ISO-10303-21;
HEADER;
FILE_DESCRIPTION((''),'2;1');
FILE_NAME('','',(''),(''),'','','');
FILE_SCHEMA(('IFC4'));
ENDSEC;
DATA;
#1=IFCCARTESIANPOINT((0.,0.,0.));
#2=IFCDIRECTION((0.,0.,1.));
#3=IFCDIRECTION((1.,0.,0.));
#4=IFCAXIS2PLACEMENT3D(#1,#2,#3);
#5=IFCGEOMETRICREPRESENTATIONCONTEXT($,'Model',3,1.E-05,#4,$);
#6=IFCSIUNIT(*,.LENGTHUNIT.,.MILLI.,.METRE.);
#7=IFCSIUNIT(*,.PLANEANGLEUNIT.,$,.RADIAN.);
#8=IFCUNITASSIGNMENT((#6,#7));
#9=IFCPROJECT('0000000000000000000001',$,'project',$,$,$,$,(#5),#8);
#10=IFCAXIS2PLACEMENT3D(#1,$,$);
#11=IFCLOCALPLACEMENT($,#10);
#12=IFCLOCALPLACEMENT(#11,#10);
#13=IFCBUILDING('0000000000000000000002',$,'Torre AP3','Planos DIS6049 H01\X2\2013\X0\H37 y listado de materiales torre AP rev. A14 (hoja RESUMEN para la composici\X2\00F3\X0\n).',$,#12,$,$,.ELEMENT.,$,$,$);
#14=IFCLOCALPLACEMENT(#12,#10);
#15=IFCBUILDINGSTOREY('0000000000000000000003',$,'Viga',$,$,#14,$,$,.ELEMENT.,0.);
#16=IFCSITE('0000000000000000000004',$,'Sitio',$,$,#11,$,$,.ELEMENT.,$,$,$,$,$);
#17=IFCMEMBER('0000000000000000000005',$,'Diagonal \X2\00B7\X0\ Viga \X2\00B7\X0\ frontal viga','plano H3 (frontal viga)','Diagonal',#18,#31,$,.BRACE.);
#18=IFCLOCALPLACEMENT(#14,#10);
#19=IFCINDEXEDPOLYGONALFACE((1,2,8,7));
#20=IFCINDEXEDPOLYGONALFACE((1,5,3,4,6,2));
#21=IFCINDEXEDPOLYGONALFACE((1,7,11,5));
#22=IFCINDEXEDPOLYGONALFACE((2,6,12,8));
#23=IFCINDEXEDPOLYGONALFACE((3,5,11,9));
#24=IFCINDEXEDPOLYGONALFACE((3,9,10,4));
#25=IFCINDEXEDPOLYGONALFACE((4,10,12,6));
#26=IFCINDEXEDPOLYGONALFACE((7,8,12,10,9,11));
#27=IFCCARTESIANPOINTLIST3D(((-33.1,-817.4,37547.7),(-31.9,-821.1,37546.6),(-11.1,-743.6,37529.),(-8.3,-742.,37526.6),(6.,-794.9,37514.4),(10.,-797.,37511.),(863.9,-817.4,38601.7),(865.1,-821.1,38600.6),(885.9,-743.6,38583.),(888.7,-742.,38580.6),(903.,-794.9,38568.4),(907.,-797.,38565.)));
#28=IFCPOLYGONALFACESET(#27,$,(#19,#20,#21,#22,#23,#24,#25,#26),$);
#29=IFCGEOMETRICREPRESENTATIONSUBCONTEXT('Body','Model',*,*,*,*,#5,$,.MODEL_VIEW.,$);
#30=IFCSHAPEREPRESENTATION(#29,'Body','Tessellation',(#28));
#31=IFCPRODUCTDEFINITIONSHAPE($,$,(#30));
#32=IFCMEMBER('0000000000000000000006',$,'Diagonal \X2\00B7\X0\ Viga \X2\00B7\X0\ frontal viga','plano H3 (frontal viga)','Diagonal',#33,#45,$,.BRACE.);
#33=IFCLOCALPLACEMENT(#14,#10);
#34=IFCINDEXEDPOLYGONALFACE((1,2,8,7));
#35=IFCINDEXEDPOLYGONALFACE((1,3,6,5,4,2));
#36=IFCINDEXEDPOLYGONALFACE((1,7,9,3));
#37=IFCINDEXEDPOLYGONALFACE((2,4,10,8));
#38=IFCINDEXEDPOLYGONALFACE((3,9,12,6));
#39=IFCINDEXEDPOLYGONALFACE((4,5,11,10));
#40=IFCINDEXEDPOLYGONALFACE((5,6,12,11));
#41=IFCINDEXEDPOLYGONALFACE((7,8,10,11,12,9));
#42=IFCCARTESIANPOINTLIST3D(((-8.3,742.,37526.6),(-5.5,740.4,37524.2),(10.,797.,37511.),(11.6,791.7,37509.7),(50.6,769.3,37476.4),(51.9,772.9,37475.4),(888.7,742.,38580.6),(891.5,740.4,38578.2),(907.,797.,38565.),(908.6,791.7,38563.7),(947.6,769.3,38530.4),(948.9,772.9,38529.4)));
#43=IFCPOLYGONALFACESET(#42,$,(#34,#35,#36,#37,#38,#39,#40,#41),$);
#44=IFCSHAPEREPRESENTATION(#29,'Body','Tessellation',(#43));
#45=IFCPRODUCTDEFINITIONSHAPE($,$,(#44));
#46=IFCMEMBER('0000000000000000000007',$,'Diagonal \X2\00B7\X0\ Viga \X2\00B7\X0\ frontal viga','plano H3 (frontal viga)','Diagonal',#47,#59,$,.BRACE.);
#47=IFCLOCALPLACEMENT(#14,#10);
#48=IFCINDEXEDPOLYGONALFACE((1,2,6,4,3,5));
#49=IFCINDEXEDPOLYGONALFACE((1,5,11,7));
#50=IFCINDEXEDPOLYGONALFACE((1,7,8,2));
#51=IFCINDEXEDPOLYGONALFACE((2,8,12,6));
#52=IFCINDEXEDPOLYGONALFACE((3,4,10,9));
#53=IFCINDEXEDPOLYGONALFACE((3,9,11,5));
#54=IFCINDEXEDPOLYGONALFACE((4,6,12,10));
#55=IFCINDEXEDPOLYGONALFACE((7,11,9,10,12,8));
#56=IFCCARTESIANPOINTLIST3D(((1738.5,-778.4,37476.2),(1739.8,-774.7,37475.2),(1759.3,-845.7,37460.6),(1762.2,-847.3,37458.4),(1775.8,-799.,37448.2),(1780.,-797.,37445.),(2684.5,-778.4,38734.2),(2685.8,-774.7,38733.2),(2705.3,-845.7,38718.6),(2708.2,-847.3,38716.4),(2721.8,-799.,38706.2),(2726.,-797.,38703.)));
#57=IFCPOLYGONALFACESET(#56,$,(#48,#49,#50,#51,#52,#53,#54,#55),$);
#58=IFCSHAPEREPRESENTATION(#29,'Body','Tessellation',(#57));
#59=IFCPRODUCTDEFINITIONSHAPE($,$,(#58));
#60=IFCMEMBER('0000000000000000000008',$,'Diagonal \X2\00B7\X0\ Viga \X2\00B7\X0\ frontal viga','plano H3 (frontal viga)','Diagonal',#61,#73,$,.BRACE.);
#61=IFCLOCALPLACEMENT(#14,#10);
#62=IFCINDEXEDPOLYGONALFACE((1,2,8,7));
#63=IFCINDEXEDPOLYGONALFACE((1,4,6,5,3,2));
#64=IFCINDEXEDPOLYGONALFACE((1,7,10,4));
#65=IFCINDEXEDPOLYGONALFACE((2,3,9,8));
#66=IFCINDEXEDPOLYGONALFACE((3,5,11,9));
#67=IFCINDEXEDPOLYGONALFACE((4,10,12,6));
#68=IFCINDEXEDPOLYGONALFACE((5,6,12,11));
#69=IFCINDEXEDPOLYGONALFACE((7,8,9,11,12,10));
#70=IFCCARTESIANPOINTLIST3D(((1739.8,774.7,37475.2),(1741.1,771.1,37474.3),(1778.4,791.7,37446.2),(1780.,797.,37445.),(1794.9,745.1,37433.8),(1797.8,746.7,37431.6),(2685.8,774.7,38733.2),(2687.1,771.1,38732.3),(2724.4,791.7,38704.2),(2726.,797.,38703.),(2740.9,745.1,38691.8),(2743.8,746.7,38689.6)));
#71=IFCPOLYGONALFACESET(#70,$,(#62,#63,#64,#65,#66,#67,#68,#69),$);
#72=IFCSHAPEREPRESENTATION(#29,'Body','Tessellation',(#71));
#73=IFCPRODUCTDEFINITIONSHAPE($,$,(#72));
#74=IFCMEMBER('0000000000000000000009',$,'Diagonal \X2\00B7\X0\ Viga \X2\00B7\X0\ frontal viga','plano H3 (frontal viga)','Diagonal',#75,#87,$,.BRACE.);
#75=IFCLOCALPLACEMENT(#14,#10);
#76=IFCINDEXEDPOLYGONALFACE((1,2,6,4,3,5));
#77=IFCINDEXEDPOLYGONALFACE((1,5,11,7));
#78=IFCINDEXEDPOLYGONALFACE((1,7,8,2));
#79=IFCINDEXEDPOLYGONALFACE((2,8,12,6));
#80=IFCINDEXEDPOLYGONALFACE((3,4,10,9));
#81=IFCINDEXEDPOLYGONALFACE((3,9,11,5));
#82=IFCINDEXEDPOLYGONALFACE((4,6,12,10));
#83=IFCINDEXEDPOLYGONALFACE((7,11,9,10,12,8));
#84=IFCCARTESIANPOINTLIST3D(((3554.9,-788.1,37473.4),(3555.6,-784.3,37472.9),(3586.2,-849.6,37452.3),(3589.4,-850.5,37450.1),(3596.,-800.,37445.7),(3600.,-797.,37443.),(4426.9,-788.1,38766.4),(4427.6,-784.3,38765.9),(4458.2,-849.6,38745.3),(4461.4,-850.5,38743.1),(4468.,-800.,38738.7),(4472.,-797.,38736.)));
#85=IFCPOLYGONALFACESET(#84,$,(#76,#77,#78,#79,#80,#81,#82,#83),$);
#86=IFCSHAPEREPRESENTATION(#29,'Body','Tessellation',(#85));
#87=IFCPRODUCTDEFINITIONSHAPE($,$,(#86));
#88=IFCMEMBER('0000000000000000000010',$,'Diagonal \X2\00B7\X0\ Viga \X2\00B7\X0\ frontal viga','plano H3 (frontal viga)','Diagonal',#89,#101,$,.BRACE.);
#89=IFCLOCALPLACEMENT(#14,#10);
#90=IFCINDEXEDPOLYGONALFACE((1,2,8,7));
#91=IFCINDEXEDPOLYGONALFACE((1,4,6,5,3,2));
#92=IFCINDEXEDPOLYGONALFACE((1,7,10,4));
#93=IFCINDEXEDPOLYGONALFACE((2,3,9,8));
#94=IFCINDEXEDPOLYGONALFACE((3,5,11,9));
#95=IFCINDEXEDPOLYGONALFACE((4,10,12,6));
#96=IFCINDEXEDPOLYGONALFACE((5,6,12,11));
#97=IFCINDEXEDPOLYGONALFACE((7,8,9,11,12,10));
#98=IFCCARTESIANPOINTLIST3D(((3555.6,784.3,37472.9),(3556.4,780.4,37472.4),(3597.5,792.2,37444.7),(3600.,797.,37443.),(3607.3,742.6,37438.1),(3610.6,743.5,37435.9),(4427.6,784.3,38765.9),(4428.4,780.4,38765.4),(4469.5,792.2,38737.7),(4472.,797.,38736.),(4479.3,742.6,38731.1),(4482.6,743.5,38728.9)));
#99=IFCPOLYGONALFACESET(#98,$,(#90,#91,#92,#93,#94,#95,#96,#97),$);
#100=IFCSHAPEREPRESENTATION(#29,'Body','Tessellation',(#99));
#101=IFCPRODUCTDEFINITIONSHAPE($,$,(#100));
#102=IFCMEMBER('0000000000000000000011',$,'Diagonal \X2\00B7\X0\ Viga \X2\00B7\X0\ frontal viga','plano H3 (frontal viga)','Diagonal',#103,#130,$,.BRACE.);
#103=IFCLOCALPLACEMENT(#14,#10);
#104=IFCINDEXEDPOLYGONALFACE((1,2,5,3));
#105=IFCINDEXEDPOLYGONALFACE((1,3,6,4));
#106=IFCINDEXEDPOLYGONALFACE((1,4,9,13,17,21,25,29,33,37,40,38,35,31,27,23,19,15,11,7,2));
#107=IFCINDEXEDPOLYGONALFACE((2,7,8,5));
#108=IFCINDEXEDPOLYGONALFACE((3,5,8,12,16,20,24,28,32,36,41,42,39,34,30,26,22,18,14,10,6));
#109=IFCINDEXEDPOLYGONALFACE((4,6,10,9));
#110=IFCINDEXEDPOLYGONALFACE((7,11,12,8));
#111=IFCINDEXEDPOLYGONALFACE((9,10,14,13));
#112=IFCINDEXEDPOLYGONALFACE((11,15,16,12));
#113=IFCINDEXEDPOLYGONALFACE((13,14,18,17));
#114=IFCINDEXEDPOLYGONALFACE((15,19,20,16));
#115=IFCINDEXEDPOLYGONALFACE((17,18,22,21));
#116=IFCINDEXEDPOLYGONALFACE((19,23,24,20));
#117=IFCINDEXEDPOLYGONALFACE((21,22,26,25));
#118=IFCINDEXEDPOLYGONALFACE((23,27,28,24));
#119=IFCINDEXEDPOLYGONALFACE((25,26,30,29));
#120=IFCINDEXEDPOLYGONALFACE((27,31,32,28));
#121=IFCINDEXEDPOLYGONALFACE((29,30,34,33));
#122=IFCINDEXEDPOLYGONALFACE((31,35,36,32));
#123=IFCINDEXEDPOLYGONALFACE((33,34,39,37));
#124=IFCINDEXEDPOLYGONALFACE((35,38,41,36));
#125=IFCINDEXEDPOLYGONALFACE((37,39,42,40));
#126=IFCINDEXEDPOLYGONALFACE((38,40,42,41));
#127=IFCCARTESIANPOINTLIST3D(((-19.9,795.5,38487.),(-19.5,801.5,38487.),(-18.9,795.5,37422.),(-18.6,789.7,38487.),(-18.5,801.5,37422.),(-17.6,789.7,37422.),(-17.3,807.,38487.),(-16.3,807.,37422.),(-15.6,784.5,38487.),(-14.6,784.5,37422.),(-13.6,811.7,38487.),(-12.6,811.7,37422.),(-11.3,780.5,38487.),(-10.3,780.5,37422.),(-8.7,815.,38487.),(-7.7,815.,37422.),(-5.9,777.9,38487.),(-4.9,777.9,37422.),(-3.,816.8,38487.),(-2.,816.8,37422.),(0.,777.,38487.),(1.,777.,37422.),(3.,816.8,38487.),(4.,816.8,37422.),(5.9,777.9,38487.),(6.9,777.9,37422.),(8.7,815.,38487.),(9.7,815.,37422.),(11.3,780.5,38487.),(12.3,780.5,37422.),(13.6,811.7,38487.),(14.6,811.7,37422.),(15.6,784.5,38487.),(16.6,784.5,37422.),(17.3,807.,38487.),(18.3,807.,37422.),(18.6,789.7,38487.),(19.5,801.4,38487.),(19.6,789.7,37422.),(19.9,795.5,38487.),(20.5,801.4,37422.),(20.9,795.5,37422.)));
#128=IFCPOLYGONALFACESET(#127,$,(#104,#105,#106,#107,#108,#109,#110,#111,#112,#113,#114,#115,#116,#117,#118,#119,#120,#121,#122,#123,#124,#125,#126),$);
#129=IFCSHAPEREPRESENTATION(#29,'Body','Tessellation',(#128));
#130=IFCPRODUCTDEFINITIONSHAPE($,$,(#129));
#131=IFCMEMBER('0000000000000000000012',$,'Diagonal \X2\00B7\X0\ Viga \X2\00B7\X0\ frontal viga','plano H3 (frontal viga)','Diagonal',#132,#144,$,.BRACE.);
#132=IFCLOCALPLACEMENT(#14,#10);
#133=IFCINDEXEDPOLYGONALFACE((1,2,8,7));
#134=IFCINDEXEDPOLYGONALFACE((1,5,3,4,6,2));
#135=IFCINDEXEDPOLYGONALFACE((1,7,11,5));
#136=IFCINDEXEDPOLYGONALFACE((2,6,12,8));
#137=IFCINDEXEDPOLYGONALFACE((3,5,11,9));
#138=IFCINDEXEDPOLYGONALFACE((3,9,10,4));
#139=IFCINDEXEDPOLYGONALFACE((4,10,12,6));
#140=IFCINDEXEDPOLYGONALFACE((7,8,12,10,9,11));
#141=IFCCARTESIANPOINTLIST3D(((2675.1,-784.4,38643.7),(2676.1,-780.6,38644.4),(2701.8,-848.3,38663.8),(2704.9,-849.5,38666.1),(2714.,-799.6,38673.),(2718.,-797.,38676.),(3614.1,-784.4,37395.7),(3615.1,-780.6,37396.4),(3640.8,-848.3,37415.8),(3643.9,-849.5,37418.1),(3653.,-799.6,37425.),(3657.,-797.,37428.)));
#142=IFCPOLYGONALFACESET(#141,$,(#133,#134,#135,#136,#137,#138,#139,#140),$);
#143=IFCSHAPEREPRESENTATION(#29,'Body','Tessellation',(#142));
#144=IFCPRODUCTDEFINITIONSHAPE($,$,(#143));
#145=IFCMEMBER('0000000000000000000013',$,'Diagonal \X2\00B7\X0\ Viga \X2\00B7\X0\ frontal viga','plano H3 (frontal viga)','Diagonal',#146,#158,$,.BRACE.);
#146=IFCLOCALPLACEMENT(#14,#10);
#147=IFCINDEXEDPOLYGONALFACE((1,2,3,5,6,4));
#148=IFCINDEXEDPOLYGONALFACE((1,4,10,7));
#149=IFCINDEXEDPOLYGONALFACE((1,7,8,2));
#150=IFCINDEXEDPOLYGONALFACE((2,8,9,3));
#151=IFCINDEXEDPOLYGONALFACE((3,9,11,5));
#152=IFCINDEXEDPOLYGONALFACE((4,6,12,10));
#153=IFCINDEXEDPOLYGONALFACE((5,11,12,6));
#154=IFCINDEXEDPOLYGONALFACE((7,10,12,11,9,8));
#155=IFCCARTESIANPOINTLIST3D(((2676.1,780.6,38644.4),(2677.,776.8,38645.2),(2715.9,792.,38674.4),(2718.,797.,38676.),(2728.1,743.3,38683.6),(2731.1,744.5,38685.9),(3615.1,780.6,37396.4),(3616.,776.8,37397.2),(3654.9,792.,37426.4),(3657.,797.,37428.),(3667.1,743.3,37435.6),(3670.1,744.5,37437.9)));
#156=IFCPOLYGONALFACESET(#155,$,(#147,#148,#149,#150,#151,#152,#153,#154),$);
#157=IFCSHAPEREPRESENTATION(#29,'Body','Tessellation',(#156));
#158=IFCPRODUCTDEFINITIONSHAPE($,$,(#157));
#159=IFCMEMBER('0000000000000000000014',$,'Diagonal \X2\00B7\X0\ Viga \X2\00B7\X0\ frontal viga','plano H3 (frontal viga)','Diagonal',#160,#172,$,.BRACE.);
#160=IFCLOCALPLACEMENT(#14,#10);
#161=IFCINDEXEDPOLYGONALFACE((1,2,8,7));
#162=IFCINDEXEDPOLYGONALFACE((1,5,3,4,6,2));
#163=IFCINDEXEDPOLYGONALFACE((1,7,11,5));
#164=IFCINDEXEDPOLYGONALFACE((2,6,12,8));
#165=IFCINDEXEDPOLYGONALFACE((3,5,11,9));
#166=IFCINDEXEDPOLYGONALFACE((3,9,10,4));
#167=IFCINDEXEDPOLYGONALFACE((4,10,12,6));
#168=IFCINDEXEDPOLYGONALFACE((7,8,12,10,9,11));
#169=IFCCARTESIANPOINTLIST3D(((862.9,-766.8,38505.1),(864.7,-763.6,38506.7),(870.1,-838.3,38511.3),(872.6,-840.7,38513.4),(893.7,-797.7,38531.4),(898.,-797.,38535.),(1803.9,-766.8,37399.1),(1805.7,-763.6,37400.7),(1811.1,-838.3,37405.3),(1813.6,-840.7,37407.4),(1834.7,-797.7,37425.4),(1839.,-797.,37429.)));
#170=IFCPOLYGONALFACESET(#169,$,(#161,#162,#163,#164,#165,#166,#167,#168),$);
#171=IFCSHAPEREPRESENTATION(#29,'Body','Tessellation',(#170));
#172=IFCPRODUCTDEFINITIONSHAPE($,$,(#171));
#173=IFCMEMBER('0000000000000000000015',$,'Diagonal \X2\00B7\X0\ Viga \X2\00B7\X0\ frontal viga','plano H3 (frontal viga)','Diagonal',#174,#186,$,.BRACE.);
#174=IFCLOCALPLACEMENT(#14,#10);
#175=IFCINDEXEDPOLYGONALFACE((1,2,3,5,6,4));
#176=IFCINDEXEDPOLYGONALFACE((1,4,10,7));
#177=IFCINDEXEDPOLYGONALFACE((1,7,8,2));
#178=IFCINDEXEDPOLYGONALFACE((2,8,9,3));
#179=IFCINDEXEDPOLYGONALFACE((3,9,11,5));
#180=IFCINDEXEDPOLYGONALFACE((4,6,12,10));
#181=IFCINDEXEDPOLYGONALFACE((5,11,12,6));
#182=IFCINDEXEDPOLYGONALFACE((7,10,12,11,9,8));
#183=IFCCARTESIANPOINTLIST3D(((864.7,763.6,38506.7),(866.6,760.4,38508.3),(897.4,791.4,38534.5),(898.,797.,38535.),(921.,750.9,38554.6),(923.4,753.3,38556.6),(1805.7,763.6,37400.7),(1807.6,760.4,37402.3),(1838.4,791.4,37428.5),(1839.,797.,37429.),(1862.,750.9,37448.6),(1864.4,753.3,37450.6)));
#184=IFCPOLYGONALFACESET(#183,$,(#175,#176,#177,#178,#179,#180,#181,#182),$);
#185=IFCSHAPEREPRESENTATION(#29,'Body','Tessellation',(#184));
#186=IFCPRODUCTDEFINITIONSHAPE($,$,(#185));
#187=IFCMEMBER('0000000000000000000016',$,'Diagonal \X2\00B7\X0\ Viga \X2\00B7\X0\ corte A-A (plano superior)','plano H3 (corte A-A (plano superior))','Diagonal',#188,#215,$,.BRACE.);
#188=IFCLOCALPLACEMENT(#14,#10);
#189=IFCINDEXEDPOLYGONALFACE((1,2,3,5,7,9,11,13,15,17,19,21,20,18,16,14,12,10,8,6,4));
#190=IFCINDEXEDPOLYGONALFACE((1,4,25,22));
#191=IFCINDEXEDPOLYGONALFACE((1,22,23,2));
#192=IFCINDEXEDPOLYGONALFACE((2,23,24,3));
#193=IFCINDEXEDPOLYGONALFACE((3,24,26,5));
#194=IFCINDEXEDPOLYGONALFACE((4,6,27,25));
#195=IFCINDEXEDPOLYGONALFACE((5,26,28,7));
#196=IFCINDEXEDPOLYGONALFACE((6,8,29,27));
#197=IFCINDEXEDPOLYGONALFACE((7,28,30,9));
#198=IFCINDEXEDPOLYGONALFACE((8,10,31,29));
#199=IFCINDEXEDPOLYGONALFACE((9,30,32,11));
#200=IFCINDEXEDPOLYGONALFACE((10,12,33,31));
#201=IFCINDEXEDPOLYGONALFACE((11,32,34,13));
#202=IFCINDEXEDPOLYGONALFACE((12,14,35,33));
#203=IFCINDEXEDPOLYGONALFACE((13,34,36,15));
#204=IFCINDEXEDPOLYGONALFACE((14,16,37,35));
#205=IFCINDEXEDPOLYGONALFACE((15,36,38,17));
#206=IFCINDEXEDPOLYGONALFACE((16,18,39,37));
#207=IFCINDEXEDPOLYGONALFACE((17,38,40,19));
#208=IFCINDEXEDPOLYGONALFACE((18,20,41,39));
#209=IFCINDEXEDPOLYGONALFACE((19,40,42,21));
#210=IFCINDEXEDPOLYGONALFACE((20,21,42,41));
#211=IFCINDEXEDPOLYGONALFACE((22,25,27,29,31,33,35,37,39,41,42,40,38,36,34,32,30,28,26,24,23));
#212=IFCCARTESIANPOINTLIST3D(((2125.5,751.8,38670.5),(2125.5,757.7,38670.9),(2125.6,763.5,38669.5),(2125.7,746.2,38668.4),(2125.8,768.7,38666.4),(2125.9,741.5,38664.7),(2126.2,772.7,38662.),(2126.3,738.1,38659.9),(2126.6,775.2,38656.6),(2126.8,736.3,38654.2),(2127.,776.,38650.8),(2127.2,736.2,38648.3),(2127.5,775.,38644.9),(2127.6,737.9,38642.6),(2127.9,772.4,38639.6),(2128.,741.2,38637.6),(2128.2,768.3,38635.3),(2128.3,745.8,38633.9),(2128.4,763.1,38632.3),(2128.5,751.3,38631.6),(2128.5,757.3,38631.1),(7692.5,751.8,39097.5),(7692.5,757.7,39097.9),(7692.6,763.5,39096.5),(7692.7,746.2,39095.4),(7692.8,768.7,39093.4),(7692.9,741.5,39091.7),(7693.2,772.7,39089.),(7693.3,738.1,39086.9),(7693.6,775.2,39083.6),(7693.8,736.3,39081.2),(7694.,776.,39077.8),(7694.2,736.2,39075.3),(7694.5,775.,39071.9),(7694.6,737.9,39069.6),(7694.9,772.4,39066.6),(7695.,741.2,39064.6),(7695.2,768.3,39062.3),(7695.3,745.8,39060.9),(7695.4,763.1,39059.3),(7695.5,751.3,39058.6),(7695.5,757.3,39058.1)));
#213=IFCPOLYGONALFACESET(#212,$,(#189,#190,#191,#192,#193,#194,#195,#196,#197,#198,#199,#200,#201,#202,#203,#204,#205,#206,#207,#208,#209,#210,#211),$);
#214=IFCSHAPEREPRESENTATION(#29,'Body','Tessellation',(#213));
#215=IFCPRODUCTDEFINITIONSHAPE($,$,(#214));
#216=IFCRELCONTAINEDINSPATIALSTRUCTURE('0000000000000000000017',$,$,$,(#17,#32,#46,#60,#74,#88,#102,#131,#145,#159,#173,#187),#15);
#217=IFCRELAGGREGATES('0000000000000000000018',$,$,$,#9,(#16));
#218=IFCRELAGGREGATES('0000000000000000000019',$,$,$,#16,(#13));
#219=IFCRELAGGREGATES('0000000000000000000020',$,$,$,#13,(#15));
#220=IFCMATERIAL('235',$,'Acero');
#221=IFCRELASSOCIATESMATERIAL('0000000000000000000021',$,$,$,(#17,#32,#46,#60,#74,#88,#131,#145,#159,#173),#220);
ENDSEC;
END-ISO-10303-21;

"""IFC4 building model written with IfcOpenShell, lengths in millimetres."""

from ifc_helpers import new_model, si_unit, frame, frame_2d, origin, origin_with_axes, place, context, subcontext, project, spatial, circle, l_section, extrude, material, element, save


model = new_model("IFC4")

# Units and contexts
model_context = context("Model", 3, precision=1e-05, world=origin_with_axes())
body_context = subcontext(model_context, "Body", "Model", "MODEL_VIEW")
ifc_project = project(units=[si_unit("LENGTHUNIT", "METRE", prefix="MILLI"), si_unit("PLANEANGLEUNIT", "RADIAN")], contexts=[model_context])

# Site, building, storey
site_placement = place(None, origin())
site = spatial("IfcSite", under=ifc_project, at=site_placement, Name="Sitio", CompositionType="ELEMENT")
building_placement = place(site_placement, origin())
building = spatial("IfcBuilding", under=site, at=building_placement, Name="Torre AP3", Description="Planos DIS6049 H01–H37 y listado de materiales torre AP rev. A14 (hoja RESUMEN para la composición).", CompositionType="ELEMENT")
storey_placement = place(building_placement, origin())
storey = spatial("IfcBuildingStorey", under=building, at=storey_placement, Name="Viga", CompositionType="ELEMENT", Elevation=0.0)

# Members
ifc_material = material(Name="235", Category="Acero")
for number, where, z_axis, x_axis, name in (
    (1, (10.0, -797.0, 37511.0), (0.64811, 0.0, 0.761547), (-0.305596, 0.915954, 0.260076), "Diagonal · Viga · frontal viga"),
    (2, (10.0, 797.0, 37511.0), (0.64811, 0.0, 0.761547), (-0.305596, -0.915954, 0.260076), "Diagonal · Viga · frontal viga"),
):
    element("IfcMember", number, at=place(storey_placement, frame(where, z_axis=z_axis, x_axis=x_axis)), inside=storey, material=ifc_material, Name=name, Description="plano H3 (frontal viga)", ObjectType="Diagonal", PredefinedType="BRACE", context=body_context, shape_type="SweptSolid", body=[
        extrude(l_section(Depth=60.0, Width=60.0, Thickness=4.0, at=frame_2d((30.0, 30.0))), None, (0.0, 0.0, 1.0), 1384.0),
    ])
for number, where, z_axis, x_axis, name in (
    (3, (1780.0, -797.0, 37445.0), (0.601016, 0.0, 0.799237), (-0.730849, 0.404737, 0.549589), "Diagonal · Viga · frontal viga"),
    (4, (1780.0, 797.0, 37445.0), (0.601016, 0.0, 0.799237), (-0.730849, -0.404737, 0.549589), "Diagonal · Viga · frontal viga"),
):
    element("IfcMember", number, at=place(storey_placement, frame(where, z_axis=z_axis, x_axis=x_axis)), inside=storey, material=ifc_material, Name=name, Description="plano H3 (frontal viga)", ObjectType="Diagonal", PredefinedType="BRACE", context=body_context, shape_type="SweptSolid", body=[
        extrude(l_section(Depth=55.0, Width=55.0, Thickness=4.0, at=frame_2d((27.5, 27.5))), None, (0.0, 0.0, 1.0), 1574.0),
    ])
for number, where, z_axis, x_axis, name in (
    (5, (3600.0, -797.0, 37443.0), (0.559131, 0.0, 0.829079), (-0.806517, 0.231702, 0.543916), "Diagonal · Viga · frontal viga"),
    (6, (3600.0, 797.0, 37443.0), (0.559131, 0.0, 0.829079), (-0.806517, -0.231702, 0.543916), "Diagonal · Viga · frontal viga"),
):
    element("IfcMember", number, at=place(storey_placement, frame(where, z_axis=z_axis, x_axis=x_axis)), inside=storey, material=ifc_material, Name=name, Description="plano H3 (frontal viga)", ObjectType="Diagonal", PredefinedType="BRACE", context=body_context, shape_type="SweptSolid", body=[
        extrude(l_section(Depth=55.0, Width=55.0, Thickness=4.0, at=frame_2d((27.5, 27.5))), None, (0.0, 0.0, 1.0), 1559.6),
    ])
member_1_placement = place(storey_placement, frame((1.0, 797.0, 37422.0), z_axis=(-0.000939, 0.0, 1.0), x_axis=(-0.000627, -1.0, -0.000001)))
element("IfcMember", 7, at=member_1_placement, inside=storey, Name="Diagonal · Viga · frontal viga", Description="plano H3 (frontal viga)", ObjectType="Diagonal", PredefinedType="BRACE", context=body_context, shape_type="SweptSolid", body=[
    extrude(circle(Radius=20.0), None, (0.0, 0.0, 1.0), 1065.0),
])
for number, where, z_axis, x_axis, name in (
    (8, (3657.0, -797.0, 37428.0), (-0.601229, 0.0, 0.799077), (-0.762614, 0.298631, -0.573794), "Diagonal · Viga · frontal viga"),
    (9, (3657.0, 797.0, 37428.0), (-0.601229, 0.0, 0.799077), (-0.762614, -0.298631, -0.573794), "Diagonal · Viga · frontal viga"),
):
    element("IfcMember", number, at=place(storey_placement, frame(where, z_axis=z_axis, x_axis=x_axis)), inside=storey, material=ifc_material, Name=name, Description="plano H3 (frontal viga)", ObjectType="Diagonal", PredefinedType="BRACE", context=body_context, shape_type="SweptSolid", body=[
        extrude(l_section(Depth=55.0, Width=55.0, Thickness=4.0, at=frame_2d((27.5, 27.5))), None, (0.0, 0.0, 1.0), 1561.8),
    ])
for number, where, z_axis, x_axis, name in (
    (10, (1839.0, -797.0, 37429.0), (-0.648008, 0.0, 0.761633), (-0.605023, 0.607426, -0.514762), "Diagonal · Viga · frontal viga"),
    (11, (1839.0, 797.0, 37429.0), (-0.648008, 0.0, 0.761633), (-0.605023, -0.607426, -0.514762), "Diagonal · Viga · frontal viga"),
):
    element("IfcMember", number, at=place(storey_placement, frame(where, z_axis=z_axis, x_axis=x_axis)), inside=storey, material=ifc_material, Name=name, Description="plano H3 (frontal viga)", ObjectType="Diagonal", PredefinedType="BRACE", context=body_context, shape_type="SweptSolid", body=[
        extrude(l_section(Depth=55.0, Width=55.0, Thickness=4.0, at=frame_2d((27.5, 27.5))), None, (0.0, 0.0, 1.0), 1452.1),
    ])
member_2_placement = place(storey_placement, frame((2127.0, 756.0, 38651.0), z_axis=(0.997071, 0.0, 0.076477), x_axis=(-0.034023, -0.895589, 0.44358)))
element("IfcMember", 12, at=member_2_placement, inside=storey, Name="Diagonal · Viga · corte A-A (plano superior)", Description="plano H3 (corte A-A (plano superior))", ObjectType="Diagonal", PredefinedType="BRACE", context=body_context, shape_type="SweptSolid", body=[
    extrude(circle(Radius=20.0), None, (0.0, 0.0, 1.0), 5583.4),
])

save(model, "model.ifc")
